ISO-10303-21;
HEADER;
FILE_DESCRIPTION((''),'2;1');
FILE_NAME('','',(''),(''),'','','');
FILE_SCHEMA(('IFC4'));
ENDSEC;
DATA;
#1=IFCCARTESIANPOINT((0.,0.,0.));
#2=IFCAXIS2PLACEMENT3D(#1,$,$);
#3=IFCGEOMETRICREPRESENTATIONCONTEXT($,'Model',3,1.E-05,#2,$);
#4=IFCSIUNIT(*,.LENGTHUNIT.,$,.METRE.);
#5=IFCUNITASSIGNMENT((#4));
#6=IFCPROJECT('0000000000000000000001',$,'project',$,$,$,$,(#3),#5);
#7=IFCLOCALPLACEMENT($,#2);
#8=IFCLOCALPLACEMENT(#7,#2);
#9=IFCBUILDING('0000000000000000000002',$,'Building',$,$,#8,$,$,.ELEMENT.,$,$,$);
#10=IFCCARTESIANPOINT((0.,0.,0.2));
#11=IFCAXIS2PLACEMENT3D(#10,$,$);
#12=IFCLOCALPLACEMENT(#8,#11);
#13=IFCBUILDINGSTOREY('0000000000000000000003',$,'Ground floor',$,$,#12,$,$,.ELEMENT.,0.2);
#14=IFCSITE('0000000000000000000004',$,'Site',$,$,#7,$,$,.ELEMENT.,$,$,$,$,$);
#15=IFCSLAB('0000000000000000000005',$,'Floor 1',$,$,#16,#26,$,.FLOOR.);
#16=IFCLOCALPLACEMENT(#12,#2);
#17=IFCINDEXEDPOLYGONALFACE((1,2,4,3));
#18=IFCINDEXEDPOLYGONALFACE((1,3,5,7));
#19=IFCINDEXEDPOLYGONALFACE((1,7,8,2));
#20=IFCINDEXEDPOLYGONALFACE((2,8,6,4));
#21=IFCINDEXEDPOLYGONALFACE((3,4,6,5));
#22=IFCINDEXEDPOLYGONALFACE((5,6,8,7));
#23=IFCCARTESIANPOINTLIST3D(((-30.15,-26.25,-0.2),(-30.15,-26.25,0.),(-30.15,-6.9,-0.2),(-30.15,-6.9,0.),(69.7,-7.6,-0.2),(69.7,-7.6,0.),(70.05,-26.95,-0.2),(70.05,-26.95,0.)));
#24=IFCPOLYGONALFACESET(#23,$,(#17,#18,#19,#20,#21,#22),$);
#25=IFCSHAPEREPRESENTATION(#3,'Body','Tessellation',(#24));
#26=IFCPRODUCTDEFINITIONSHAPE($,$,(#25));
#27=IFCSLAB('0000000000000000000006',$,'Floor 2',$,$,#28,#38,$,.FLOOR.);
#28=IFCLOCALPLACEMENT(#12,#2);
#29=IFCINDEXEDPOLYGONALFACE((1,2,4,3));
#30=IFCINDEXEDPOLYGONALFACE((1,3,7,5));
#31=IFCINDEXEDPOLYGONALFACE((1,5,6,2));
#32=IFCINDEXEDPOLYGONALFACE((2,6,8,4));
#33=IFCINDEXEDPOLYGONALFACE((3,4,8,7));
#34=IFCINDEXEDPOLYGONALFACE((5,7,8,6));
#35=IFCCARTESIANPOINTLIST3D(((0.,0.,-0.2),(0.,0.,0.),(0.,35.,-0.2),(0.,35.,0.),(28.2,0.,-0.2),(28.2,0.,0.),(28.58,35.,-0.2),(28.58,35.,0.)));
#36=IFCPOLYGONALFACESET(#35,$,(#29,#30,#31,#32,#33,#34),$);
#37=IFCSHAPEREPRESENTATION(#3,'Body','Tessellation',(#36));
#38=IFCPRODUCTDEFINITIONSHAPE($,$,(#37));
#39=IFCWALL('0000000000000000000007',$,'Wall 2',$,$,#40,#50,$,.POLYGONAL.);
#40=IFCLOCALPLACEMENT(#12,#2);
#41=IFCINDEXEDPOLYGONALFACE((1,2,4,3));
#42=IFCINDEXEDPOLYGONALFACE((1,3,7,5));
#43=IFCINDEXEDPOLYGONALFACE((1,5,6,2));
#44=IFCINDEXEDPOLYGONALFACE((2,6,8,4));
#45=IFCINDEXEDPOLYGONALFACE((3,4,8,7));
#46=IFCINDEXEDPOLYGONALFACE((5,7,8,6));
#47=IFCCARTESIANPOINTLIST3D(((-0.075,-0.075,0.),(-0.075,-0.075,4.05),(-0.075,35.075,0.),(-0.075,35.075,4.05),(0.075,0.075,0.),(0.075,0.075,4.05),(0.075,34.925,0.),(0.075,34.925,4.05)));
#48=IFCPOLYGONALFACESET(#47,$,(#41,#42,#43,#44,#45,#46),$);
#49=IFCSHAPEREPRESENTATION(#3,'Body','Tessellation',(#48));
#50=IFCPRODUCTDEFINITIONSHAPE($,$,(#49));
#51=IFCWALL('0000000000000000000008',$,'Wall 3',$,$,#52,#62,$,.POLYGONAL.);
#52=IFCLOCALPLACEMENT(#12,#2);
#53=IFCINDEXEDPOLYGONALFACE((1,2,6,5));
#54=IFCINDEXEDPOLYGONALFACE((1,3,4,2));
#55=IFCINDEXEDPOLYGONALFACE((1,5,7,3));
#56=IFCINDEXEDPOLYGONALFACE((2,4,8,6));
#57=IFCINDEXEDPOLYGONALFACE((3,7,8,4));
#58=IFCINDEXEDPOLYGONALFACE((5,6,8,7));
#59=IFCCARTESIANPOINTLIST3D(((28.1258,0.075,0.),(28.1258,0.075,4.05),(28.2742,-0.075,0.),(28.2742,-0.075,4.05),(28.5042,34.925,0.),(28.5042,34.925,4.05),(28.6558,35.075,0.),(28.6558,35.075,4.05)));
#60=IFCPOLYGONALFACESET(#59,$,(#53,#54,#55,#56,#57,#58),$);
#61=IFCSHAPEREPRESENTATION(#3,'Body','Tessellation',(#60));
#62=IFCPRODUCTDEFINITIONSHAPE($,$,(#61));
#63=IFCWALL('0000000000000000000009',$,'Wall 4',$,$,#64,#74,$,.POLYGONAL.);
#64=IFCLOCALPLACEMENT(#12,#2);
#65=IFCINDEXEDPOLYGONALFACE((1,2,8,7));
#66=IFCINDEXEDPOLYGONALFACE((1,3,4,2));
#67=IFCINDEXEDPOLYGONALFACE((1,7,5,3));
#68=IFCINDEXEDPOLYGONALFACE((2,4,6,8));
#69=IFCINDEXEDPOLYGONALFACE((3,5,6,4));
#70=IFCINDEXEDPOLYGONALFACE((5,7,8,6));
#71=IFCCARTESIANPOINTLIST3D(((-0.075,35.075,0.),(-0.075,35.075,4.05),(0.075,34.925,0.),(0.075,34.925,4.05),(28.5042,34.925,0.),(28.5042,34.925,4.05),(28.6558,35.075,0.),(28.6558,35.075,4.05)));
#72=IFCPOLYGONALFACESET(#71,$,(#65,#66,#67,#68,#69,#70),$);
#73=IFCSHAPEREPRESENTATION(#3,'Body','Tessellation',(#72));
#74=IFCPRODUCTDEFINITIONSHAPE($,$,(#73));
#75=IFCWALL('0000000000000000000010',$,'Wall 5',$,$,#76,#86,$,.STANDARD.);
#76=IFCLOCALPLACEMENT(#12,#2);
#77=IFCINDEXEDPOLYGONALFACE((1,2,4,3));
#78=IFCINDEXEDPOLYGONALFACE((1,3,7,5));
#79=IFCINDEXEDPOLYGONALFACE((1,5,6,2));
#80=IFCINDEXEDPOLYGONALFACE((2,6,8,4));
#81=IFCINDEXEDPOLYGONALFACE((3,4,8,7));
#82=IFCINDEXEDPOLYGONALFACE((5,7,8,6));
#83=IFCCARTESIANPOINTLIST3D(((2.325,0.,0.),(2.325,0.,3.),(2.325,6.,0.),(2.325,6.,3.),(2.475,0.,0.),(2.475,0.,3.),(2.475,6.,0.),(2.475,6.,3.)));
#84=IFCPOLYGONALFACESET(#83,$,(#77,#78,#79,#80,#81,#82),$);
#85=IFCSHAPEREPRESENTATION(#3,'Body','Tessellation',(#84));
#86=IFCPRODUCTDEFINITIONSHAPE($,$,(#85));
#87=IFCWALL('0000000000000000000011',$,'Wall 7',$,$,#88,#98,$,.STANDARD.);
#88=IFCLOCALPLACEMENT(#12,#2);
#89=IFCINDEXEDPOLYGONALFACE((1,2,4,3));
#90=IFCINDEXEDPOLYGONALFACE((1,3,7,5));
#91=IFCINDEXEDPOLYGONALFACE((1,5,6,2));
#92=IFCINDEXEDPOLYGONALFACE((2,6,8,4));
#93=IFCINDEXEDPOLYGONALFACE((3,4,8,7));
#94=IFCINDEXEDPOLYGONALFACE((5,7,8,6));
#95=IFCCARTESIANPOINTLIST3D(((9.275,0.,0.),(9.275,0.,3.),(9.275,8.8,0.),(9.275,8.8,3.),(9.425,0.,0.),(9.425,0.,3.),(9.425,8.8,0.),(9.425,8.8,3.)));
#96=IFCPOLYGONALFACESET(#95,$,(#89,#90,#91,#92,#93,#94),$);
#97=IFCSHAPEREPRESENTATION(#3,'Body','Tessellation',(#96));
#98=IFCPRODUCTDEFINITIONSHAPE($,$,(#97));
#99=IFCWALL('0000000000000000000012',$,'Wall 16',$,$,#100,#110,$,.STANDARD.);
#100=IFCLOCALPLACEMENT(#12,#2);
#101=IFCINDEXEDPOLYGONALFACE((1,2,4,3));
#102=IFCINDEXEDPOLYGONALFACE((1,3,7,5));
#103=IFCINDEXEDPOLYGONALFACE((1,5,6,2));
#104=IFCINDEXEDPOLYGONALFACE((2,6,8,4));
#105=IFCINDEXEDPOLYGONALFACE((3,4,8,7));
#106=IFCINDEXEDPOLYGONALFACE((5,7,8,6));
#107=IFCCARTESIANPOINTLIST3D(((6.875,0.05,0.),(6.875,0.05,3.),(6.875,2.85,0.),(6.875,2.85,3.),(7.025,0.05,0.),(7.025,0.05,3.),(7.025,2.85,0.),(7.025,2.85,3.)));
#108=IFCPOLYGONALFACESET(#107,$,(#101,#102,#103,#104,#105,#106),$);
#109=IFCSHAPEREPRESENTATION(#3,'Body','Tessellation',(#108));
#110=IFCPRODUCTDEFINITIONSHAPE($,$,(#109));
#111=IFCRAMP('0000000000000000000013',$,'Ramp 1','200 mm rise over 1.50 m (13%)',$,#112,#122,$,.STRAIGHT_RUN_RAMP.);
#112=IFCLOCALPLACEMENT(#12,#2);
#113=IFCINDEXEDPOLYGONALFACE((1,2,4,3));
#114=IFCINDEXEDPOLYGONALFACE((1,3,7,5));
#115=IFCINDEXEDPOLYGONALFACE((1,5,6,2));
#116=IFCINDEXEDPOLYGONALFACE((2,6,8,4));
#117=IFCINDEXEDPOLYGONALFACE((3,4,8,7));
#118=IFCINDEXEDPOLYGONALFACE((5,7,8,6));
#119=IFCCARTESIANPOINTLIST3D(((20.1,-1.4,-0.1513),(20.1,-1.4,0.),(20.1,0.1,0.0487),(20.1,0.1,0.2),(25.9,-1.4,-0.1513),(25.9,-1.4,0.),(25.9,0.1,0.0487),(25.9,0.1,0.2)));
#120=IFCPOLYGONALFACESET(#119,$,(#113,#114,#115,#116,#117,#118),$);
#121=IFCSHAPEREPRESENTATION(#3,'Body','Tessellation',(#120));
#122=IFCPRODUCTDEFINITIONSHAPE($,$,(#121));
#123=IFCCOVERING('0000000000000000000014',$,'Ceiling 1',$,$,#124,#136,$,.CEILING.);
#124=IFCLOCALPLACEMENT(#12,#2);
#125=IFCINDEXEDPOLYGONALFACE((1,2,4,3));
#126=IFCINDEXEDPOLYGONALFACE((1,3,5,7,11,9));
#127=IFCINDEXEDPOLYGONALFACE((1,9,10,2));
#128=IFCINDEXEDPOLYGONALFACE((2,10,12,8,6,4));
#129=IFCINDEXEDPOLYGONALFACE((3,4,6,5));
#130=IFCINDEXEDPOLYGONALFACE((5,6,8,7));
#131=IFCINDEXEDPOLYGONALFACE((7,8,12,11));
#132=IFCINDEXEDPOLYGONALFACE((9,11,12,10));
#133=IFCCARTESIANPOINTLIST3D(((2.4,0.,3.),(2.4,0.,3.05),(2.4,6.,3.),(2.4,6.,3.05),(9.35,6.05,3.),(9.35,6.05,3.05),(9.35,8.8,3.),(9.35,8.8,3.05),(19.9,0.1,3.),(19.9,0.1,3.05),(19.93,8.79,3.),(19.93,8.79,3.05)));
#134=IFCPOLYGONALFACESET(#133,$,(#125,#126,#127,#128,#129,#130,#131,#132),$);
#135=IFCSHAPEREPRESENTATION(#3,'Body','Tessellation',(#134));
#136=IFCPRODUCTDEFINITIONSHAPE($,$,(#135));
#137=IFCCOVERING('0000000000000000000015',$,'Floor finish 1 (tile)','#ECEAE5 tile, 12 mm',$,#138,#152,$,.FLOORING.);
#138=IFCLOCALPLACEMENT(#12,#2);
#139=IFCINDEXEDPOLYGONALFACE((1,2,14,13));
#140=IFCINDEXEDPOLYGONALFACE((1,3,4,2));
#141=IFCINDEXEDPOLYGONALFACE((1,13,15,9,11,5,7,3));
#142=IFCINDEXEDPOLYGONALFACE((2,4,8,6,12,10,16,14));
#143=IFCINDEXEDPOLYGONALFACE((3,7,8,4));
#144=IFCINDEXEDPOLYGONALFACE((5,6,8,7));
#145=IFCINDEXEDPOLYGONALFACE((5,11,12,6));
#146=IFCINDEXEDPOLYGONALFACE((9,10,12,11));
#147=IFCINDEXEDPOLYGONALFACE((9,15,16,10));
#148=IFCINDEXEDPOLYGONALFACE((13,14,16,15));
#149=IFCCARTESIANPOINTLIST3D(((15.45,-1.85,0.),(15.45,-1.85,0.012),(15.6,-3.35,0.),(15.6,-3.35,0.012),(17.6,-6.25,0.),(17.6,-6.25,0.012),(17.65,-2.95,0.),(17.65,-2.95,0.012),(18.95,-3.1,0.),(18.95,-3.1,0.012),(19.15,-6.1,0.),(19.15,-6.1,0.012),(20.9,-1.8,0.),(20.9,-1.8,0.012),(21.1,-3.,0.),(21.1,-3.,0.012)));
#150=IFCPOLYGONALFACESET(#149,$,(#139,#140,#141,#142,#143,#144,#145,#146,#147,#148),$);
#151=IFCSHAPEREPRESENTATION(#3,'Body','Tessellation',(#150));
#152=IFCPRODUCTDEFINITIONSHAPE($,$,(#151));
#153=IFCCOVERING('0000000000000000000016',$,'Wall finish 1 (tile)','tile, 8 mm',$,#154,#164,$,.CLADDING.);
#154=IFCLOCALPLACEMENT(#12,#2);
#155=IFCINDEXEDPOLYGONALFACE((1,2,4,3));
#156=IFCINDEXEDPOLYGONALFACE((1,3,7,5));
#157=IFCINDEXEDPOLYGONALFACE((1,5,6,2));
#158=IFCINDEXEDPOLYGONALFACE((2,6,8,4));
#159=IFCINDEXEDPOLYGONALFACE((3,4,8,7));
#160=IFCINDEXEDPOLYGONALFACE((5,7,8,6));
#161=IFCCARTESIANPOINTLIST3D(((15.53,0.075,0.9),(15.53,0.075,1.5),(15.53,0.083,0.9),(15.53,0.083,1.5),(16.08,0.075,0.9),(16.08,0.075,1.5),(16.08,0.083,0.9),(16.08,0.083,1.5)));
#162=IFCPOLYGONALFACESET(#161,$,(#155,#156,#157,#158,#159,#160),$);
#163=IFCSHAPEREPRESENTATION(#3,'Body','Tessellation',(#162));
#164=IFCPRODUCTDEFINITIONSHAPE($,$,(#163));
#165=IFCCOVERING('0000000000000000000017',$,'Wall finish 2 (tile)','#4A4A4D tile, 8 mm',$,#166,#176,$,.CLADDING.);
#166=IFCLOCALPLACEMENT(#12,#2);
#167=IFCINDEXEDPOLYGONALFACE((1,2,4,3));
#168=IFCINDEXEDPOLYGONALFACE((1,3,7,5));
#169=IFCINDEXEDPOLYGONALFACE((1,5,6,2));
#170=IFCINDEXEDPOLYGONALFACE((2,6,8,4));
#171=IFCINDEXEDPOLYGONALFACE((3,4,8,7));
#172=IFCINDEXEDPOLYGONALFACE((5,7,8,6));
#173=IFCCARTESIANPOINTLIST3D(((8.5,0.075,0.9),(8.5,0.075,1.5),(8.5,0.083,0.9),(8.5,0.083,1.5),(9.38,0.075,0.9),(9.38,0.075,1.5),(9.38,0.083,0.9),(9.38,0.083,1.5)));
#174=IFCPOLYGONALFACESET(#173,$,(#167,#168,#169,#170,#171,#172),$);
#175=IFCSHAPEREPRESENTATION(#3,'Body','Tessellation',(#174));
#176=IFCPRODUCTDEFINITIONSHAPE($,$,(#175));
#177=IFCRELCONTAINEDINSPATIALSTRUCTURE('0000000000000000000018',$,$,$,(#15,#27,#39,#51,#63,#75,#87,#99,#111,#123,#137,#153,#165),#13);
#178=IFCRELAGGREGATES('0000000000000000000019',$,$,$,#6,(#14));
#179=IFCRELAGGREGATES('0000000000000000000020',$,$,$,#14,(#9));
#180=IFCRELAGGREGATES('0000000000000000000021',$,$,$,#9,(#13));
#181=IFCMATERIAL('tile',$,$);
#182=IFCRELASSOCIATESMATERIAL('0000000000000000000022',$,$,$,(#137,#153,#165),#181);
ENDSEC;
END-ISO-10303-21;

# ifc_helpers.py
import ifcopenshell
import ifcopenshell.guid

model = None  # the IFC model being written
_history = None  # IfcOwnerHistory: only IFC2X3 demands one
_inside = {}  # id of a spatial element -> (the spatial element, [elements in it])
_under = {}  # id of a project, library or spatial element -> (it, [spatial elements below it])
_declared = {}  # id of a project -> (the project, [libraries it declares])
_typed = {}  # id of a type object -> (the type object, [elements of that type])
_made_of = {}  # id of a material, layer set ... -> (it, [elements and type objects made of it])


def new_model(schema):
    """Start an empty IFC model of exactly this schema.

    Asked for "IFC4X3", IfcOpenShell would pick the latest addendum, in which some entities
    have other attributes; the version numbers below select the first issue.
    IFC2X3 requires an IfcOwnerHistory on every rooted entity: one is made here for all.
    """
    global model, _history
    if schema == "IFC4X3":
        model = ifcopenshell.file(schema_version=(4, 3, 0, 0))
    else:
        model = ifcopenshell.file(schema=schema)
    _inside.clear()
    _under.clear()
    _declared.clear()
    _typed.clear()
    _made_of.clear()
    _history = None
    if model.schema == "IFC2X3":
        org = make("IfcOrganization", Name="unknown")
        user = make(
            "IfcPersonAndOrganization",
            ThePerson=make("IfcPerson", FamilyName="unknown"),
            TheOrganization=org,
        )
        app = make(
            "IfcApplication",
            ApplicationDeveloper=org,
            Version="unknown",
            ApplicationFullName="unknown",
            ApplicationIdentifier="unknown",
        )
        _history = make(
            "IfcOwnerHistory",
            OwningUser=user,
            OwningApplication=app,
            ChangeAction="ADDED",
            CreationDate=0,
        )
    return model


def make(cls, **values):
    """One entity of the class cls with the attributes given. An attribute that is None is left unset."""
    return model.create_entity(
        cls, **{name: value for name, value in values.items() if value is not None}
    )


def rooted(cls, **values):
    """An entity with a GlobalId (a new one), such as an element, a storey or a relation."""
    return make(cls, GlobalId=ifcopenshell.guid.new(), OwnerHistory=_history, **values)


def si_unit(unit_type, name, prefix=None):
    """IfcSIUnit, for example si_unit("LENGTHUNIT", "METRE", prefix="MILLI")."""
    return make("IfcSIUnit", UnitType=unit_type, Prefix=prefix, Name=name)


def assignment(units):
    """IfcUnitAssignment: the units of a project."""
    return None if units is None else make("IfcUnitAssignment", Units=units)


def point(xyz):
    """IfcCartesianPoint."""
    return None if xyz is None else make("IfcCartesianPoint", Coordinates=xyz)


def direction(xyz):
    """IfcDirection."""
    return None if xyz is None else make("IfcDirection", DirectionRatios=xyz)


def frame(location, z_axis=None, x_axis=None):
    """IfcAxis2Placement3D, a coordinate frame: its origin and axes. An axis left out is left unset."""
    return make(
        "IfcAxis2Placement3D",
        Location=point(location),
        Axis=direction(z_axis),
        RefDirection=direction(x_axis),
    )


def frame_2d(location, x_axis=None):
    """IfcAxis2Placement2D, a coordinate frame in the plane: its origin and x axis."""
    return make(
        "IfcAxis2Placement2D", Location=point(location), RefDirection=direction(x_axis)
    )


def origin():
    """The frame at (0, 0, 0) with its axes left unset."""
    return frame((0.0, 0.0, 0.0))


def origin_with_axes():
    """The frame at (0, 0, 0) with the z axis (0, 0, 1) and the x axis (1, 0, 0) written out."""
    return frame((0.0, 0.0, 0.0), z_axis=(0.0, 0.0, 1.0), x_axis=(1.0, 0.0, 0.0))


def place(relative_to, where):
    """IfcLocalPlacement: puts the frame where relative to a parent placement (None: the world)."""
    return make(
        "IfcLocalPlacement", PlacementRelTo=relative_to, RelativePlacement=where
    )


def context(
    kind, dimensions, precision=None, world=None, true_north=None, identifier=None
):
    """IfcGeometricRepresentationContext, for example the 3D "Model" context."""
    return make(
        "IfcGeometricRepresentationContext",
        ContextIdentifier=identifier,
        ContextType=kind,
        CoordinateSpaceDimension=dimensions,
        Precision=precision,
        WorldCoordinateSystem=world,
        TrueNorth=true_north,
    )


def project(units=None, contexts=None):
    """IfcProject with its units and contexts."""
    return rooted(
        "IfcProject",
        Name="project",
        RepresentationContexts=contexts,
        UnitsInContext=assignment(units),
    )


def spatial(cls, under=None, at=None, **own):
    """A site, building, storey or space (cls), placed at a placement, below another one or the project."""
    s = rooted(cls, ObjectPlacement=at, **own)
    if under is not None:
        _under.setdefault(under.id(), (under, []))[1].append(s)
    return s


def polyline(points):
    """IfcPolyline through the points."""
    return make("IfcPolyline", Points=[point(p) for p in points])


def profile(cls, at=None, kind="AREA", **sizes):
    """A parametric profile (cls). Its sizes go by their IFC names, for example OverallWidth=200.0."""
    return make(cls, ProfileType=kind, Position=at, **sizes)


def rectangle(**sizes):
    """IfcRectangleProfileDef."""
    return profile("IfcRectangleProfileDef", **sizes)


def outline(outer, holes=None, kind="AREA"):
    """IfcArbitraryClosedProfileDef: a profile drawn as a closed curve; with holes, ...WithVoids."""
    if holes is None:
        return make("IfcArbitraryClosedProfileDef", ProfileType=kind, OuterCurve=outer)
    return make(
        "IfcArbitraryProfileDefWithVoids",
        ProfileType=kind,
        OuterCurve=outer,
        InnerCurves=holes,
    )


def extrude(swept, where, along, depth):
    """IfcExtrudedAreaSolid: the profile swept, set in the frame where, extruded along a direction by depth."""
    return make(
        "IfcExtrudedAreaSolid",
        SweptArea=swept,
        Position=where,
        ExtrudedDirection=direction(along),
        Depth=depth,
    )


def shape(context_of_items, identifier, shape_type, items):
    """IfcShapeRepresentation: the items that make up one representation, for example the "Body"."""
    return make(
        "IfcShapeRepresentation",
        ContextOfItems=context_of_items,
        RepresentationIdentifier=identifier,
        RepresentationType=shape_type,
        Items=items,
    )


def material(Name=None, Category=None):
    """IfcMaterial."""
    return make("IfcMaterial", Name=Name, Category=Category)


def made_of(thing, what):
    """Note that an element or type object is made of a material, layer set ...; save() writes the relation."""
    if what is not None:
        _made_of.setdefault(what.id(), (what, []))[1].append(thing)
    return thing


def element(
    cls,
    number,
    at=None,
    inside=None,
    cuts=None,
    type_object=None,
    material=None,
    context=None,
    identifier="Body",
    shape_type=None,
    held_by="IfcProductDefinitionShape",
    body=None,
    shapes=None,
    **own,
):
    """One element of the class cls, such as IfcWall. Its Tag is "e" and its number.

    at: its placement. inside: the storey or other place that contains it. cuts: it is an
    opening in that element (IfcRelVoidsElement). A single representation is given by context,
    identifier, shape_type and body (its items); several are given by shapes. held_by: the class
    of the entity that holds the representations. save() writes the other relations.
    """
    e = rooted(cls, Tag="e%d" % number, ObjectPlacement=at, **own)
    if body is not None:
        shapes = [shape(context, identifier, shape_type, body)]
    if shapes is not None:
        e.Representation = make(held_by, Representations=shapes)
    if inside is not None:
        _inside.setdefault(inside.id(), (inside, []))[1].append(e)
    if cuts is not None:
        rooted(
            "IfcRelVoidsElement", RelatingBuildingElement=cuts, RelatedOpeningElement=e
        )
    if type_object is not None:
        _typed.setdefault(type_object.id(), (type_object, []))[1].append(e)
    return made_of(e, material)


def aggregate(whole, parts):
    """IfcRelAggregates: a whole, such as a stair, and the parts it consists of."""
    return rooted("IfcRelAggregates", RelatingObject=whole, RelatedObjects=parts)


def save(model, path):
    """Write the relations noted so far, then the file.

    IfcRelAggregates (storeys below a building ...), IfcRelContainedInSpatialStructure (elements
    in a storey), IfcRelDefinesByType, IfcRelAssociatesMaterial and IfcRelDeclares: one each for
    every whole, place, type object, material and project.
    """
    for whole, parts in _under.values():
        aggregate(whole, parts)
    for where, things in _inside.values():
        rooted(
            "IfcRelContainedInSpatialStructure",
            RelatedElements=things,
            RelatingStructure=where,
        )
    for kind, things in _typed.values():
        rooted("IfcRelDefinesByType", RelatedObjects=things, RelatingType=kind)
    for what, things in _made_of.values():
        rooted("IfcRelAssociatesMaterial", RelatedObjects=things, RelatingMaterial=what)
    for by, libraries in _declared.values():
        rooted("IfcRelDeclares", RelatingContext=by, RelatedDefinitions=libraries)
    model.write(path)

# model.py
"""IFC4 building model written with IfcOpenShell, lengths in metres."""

from ifc_helpers import new_model, si_unit, frame, frame_2d, origin, origin_with_axes, place, context, project, spatial, polyline, rectangle, outline, extrude, material, element, save


model = new_model("IFC4")

# Units and contexts
model_context = context("Model", 3, precision=1e-05, world=origin())
ifc_project = project(units=[si_unit("LENGTHUNIT", "METRE")], contexts=[model_context])

# Site, building, storey
site_placement = place(None, origin())
site = spatial("IfcSite", under=ifc_project, at=site_placement, Name="Site", CompositionType="ELEMENT")
building_placement = place(site_placement, origin())
building = spatial("IfcBuilding", under=site, at=building_placement, Name="Building", CompositionType="ELEMENT")
storey_placement = place(building_placement, frame((0.0, 0.0, 0.2)))
storey = spatial("IfcBuildingStorey", under=building, at=storey_placement, Name="Ground floor", CompositionType="ELEMENT", Elevation=0.2)

# Slabs
slab_1_placement = place(storey_placement, frame((0.0, 0.0, -0.2), z_axis=(0.0, 0.0, 1.0), x_axis=(1.0, 0.0, 0.0)))
element("IfcSlab", 1, at=slab_1_placement, inside=storey, Name="Floor 1", PredefinedType="FLOOR", context=model_context, shape_type="SweptSolid", body=[
    extrude(outline(polyline([(-30.15, -6.9), (69.7, -7.6), (70.05, -26.95), (-30.15, -26.25), (-30.15, -6.9)])), origin(), (0.0, 0.0, 1.0), 0.2),
])
slab_2_placement = place(storey_placement, frame((0.0, 0.0, -0.2), z_axis=(0.0, 0.0, 1.0), x_axis=(1.0, 0.0, 0.0)))
element("IfcSlab", 2, at=slab_2_placement, inside=storey, Name="Floor 2", PredefinedType="FLOOR", context=model_context, shape_type="SweptSolid", body=[
    extrude(outline(polyline([(0.0, 0.0), (0.0, 35.0), (28.58, 35.0), (28.2, 0.0), (0.0, 0.0)])), origin(), (0.0, 0.0, 1.0), 0.2),
])

# Walls
wall_1_placement = place(storey_placement, origin_with_axes())
element("IfcWall", 3, at=wall_1_placement, inside=storey, Name="Wall 2", PredefinedType="POLYGONAL", context=model_context, shape_type="SweptSolid", body=[
    extrude(outline(polyline([(-0.075, -0.075), (0.075, 0.075), (0.075, 34.925), (-0.075, 35.075), (-0.075, -0.075)])), origin(), (0.0, 0.0, 1.0), 4.05),
])
wall_2_placement = place(storey_placement, origin_with_axes())
element("IfcWall", 4, at=wall_2_placement, inside=storey, Name="Wall 3", PredefinedType="POLYGONAL", context=model_context, shape_type="SweptSolid", body=[
    extrude(outline(polyline([(28.1258, 0.075), (28.2742, -0.075), (28.6558, 35.075), (28.5042, 34.925), (28.1258, 0.075)])), origin(), (0.0, 0.0, 1.0), 4.05),
])
wall_3_placement = place(storey_placement, origin_with_axes())
element("IfcWall", 5, at=wall_3_placement, inside=storey, Name="Wall 4", PredefinedType="POLYGONAL", context=model_context, shape_type="SweptSolid", body=[
    extrude(outline(polyline([(-0.075, 35.075), (0.075, 34.925), (28.5042, 34.925), (28.6558, 35.075), (-0.075, 35.075)])), origin(), (0.0, 0.0, 1.0), 4.05),
])
wall_4_placement = place(storey_placement, frame((2.4, 0.0, 0.0), z_axis=(0.0, 0.0, 1.0), x_axis=(0.0, 1.0, 0.0)))
element("IfcWall", 6, at=wall_4_placement, inside=storey, Name="Wall 5", PredefinedType="STANDARD", context=model_context, shape_type="SweptSolid", body=[
    extrude(rectangle(XDim=6.0, YDim=0.15, at=frame_2d((3.0, 0.0))), origin(), (0.0, 0.0, 1.0), 3.0),
])
wall_5_placement = place(storey_placement, frame((9.35, 0.0, 0.0), z_axis=(0.0, 0.0, 1.0), x_axis=(0.0, 1.0, 0.0)))
element("IfcWall", 7, at=wall_5_placement, inside=storey, Name="Wall 7", PredefinedType="STANDARD", context=model_context, shape_type="SweptSolid", body=[
    extrude(rectangle(XDim=8.8, YDim=0.15, at=frame_2d((4.4, 0.0))), origin(), (0.0, 0.0, 1.0), 3.0),
])
wall_6_placement = place(storey_placement, frame((6.95, 0.05, 0.0), z_axis=(0.0, 0.0, 1.0), x_axis=(0.0, 1.0, 0.0)))
element("IfcWall", 8, at=wall_6_placement, inside=storey, Name="Wall 16", PredefinedType="STANDARD", context=model_context, shape_type="SweptSolid", body=[
    extrude(rectangle(XDim=2.8, YDim=0.15, at=frame_2d((1.4, 0.0))), origin(), (0.0, 0.0, 1.0), 3.0),
])

# Ramp
ramp_placement = place(storey_placement, frame((23.0, -1.4, 0.0), z_axis=(0.0, 0.0, 1.0), x_axis=(0.0, 1.0, 0.0)))
element("IfcRamp", 9, at=ramp_placement, inside=storey, Name="Ramp 1", Description="200 mm rise over 1.50 m (13%)", PredefinedType="STRAIGHT_RUN_RAMP", context=model_context, shape_type="SweptSolid", body=[
    extrude(outline(polyline([(0.0, -0.1513), (1.5, 0.0487), (1.5, 0.2), (0.0, 0.0), (0.0, -0.1513)])), frame((0.0, 2.9, 0.0), z_axis=(0.0, -1.0, 0.0), x_axis=(1.0, 0.0, 0.0)), (0.0, 0.0, 1.0), 5.8),
])

# Coverings
covering_1_placement = place(storey_placement, frame((0.0, 0.0, 3.0), z_axis=(0.0, 0.0, 1.0), x_axis=(1.0, 0.0, 0.0)))
element("IfcCovering", 10, at=covering_1_placement, inside=storey, Name="Ceiling 1", PredefinedType="CEILING", context=model_context, shape_type="SweptSolid", body=[
    extrude(outline(polyline([(19.9, 0.1), (2.4, 0.0), (2.4, 6.0), (9.35, 6.05), (9.35, 8.8), (19.93, 8.79), (19.9, 0.1)])), origin(), (0.0, 0.0, 1.0), 0.05),
])
ifc_material = material(Name="tile")
covering_2_placement = place(storey_placement, origin_with_axes())
element("IfcCovering", 11, at=covering_2_placement, inside=storey, material=ifc_material, Name="Floor finish 1 (tile)", Description="#ECEAE5 tile, 12 mm", PredefinedType="FLOORING", context=model_context, shape_type="SweptSolid", body=[
    extrude(outline(polyline([(17.65, -2.95), (17.6, -6.25), (19.15, -6.1), (18.95, -3.1), (21.1, -3.0), (20.9, -1.8), (15.45, -1.85), (15.6, -3.35), (17.65, -2.95)])), origin(), (0.0, 0.0, 1.0), 0.012),
])
covering_3_placement = place(storey_placement, origin_with_axes())
element("IfcCovering", 12, at=covering_3_placement, inside=storey, material=ifc_material, Name="Wall finish 1 (tile)", Description="tile, 8 mm", PredefinedType="CLADDING", context=model_context, shape_type="SweptSolid", body=[
    extrude(outline(polyline([(15.53, 0.075), (16.08, 0.075), (16.08, 0.083), (15.53, 0.083), (15.53, 0.075)])), frame((0.0, 0.0, 0.9)), (0.0, 0.0, 1.0), 0.6),
])
covering_4_placement = place(storey_placement, origin_with_axes())
element("IfcCovering", 13, at=covering_4_placement, inside=storey, material=ifc_material, Name="Wall finish 2 (tile)", Description="#4A4A4D tile, 8 mm", PredefinedType="CLADDING", context=model_context, shape_type="SweptSolid", body=[
    extrude(outline(polyline([(8.5, 0.075), (9.38, 0.075), (9.38, 0.083), (8.5, 0.083), (8.5, 0.075)])), frame((0.0, 0.0, 0.9)), (0.0, 0.0, 1.0), 0.6),
])

save(model, "model.ifc")
